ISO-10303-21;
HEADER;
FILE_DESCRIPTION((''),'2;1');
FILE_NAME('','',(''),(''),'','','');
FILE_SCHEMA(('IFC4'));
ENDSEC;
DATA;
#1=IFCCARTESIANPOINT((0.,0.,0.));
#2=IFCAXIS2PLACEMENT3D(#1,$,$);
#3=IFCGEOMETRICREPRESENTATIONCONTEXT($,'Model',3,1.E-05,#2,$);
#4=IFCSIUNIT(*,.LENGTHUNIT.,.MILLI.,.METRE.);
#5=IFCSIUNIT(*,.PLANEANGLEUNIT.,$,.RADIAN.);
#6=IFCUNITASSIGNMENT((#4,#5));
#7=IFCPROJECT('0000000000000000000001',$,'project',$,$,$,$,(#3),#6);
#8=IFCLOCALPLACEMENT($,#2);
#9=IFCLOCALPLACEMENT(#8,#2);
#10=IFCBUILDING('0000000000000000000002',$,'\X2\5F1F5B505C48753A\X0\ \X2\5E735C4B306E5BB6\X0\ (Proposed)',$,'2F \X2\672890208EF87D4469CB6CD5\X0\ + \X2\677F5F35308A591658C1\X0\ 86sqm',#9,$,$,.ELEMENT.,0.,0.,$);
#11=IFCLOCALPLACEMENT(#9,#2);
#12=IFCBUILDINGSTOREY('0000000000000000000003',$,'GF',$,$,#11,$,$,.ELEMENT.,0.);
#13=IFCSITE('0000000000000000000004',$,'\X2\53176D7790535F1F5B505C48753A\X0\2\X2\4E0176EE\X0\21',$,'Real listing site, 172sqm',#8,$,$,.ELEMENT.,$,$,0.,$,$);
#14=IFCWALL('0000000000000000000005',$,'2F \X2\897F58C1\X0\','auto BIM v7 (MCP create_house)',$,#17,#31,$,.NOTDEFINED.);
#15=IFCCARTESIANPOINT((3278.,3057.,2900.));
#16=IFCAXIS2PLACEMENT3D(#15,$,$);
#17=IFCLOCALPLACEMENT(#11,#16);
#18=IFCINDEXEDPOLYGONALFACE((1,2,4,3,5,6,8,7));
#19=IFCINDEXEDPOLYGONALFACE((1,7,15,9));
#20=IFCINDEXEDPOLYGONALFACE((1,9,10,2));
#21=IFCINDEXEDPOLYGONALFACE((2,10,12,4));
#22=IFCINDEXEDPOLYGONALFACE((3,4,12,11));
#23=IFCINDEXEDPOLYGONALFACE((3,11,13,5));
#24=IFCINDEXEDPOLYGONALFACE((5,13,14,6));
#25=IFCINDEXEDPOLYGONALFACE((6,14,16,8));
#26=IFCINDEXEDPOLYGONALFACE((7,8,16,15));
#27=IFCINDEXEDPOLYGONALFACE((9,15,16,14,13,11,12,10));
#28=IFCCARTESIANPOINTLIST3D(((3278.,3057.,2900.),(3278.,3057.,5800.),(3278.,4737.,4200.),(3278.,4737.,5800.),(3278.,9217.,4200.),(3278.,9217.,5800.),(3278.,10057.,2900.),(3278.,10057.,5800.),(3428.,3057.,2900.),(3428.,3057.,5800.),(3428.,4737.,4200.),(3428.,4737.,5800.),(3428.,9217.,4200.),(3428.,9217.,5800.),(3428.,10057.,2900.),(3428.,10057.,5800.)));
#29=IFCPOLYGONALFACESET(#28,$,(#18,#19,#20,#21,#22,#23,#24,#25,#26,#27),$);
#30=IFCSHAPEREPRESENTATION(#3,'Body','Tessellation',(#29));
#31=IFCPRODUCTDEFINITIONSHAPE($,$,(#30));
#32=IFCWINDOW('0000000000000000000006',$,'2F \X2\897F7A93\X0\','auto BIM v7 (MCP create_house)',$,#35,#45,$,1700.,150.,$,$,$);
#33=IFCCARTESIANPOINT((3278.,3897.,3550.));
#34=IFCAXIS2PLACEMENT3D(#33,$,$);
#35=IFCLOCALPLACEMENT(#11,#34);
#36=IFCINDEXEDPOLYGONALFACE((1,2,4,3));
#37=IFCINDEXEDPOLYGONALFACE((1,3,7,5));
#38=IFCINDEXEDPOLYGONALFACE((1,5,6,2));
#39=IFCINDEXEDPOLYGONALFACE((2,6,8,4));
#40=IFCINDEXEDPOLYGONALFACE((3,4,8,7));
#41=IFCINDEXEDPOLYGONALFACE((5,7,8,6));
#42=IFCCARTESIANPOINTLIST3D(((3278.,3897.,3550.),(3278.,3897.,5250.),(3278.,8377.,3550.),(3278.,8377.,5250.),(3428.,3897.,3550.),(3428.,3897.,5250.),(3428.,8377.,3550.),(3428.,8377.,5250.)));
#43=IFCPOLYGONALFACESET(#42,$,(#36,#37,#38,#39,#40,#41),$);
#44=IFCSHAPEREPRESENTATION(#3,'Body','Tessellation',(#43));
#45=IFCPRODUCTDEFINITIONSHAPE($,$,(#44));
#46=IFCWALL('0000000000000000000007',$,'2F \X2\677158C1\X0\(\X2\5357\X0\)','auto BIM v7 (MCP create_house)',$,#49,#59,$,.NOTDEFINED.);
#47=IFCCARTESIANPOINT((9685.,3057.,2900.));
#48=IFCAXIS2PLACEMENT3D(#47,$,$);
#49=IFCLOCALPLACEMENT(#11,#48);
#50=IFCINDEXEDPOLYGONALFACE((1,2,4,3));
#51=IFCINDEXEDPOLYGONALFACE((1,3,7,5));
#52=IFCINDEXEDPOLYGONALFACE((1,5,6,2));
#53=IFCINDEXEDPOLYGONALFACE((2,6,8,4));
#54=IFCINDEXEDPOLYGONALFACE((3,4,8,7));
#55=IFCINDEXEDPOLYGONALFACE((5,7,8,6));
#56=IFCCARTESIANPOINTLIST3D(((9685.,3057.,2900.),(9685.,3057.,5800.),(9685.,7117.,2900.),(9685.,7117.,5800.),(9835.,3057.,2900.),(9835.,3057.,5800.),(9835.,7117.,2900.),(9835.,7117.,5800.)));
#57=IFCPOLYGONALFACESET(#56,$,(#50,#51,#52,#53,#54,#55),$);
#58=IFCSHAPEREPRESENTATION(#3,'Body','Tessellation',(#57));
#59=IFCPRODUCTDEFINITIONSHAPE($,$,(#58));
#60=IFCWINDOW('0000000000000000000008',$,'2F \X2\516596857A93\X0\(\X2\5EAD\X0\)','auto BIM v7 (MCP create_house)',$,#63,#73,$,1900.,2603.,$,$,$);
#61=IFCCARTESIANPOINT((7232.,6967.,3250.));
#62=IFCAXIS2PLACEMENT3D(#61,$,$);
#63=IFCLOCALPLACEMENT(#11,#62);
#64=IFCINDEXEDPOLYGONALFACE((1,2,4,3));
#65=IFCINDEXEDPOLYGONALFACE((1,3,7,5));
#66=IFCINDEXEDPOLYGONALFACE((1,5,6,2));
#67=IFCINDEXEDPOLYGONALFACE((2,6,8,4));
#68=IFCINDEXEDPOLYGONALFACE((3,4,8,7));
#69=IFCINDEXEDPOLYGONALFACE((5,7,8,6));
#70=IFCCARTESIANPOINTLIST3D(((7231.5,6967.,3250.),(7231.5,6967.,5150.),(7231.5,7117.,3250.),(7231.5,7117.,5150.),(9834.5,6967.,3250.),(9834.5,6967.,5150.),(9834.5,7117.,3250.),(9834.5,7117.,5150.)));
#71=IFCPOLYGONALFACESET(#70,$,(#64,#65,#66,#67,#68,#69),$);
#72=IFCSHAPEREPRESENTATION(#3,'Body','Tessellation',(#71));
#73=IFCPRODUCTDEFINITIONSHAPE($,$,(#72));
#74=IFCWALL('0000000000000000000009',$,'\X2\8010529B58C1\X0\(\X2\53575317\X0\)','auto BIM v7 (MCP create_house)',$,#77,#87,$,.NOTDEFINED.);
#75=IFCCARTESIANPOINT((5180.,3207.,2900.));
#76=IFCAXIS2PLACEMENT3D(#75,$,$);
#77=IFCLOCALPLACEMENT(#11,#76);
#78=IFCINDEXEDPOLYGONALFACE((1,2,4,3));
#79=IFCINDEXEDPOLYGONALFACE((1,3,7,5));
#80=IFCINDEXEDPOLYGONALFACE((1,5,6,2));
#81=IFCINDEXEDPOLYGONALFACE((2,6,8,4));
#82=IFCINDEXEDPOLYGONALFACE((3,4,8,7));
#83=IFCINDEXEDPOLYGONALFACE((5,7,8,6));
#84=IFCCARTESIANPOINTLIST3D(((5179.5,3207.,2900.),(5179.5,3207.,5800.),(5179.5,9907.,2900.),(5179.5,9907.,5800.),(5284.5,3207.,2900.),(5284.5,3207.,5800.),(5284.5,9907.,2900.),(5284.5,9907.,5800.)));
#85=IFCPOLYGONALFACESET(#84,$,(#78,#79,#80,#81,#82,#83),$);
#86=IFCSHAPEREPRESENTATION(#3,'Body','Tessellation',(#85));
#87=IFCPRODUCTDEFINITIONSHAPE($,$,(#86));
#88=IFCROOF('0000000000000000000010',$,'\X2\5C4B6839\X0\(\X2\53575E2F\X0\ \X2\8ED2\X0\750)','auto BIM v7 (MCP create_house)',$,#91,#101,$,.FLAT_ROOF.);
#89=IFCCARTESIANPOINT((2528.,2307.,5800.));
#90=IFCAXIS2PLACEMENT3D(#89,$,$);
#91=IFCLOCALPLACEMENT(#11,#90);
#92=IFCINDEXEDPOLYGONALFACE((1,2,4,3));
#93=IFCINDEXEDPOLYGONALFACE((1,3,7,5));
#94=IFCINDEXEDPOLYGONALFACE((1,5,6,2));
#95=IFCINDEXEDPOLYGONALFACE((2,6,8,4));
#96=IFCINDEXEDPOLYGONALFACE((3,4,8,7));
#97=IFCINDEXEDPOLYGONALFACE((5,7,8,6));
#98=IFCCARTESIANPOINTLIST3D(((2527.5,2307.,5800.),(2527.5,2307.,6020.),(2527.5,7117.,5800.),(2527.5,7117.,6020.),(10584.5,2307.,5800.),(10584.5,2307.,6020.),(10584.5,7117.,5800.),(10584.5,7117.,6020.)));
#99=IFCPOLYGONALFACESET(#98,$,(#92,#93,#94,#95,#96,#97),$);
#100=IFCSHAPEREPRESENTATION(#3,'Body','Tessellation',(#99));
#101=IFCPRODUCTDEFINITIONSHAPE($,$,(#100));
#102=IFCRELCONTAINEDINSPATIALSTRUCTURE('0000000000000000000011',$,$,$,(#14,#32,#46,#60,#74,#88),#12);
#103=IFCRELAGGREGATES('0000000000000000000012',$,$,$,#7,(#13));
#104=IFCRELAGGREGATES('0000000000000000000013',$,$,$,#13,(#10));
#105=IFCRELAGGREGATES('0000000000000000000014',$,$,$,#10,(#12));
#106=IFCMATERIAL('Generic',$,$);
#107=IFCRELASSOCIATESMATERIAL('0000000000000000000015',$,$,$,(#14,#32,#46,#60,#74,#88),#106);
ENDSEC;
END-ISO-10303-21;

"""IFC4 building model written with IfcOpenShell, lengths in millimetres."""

from ifc_helpers import new_model, si_unit, frame, frame_2d, origin, place, context, project, spatial, rectangle, extrude, material, element, fill, save


model = new_model("IFC4")

# Units and contexts
model_context = context("Model", 3, precision=1e-05, world=origin())
ifc_project = project(units=[si_unit("LENGTHUNIT", "METRE", prefix="MILLI"), si_unit("PLANEANGLEUNIT", "RADIAN")], contexts=[model_context])

# Site, building, storey
site_placement = place(None, origin())
site = spatial("IfcSite", under=ifc_project, at=site_placement, Name="北海道弟子屈町2丁目21", ObjectType="Real listing site, 172sqm", CompositionType="ELEMENT", RefElevation=0.0)
building_placement = place(site_placement, origin())
building = spatial("IfcBuilding", under=site, at=building_placement, Name="弟子屈町 平屋の家 (Proposed)", ObjectType="2F 木造軸組構法 + 板張り外壁 86sqm", CompositionType="ELEMENT", ElevationOfRefHeight=0.0, ElevationOfTerrain=0.0)
storey_placement = place(building_placement, origin())
storey = spatial("IfcBuildingStorey", under=building, at=storey_placement, Name="GF", CompositionType="ELEMENT", Elevation=0.0)

# Shared definitions
ifc_material = material(Name="Generic")

# Walls, openings, windows
wall_1_placement = place(storey_placement, frame((3278.0, 3057.0, 2900.0)))
wall_1 = element("IfcWall", 1, at=wall_1_placement, inside=storey, material=ifc_material, Name="2F 西壁", Description="auto BIM v7 (MCP create_house)", PredefinedType="NOTDEFINED", context=model_context, shape_type="SweptSolid", body=[
    extrude(rectangle(XDim=150.0, YDim=7000.0, at=frame_2d((75.0, 3500.0))), frame((3278.0, 3057.0, 2900.0)), (0.0, 0.0, 1.0), 2900.0),
])
opening_1_placement = place(storey_placement, frame((3278.0, 3897.0, 3550.0)))
opening_1 = element("IfcOpeningElement", 2, at=opening_1_placement, cuts=wall_1, PredefinedType="NOTDEFINED", context=model_context, shape_type="SweptSolid", body=[
    extrude(rectangle(XDim=150.0, YDim=4480.0, at=frame_2d((75.0, 2240.0))), frame((3278.0, 3897.0, 3550.0)), (0.0, 0.0, 1.0), 1700.0),
])
window_1_placement = place(storey_placement, frame((3278.0, 3897.0, 3550.0)))
window_1 = element("IfcWindow", 3, at=window_1_placement, inside=storey, material=ifc_material, Name="2F 西窓", Description="auto BIM v7 (MCP create_house)", OverallHeight=1700.0, OverallWidth=150.0, context=model_context, shape_type="SweptSolid", body=[
    extrude(rectangle(XDim=150.0, YDim=4480.0, at=frame_2d((75.0, 2240.0))), frame((3278.0, 3897.0, 3550.0)), (0.0, 0.0, 1.0), 1700.0),
])
fill(opening_1, window_1)
wall_2_placement = place(storey_placement, frame((9685.0, 3057.0, 2900.0)))
wall_2 = element("IfcWall", 4, at=wall_2_placement, inside=storey, material=ifc_material, Name="2F 東壁(南)", Description="auto BIM v7 (MCP create_house)", PredefinedType="NOTDEFINED", context=model_context, shape_type="SweptSolid", body=[
    extrude(rectangle(XDim=150.0, YDim=4060.0, at=frame_2d((75.0, 2030.0))), frame((9685.0, 3057.0, 2900.0)), (0.0, 0.0, 1.0), 2900.0),
])
opening_2_placement = place(storey_placement, frame((7232.0, 6967.0, 3250.0)))
opening_2 = element("IfcOpeningElement", 5, at=opening_2_placement, cuts=wall_2, PredefinedType="NOTDEFINED", context=model_context, shape_type="SweptSolid", body=[
    extrude(rectangle(XDim=2603.0, YDim=150.0, at=frame_2d((1301.0, 75.0))), frame((7232.0, 6967.0, 3250.0)), (0.0, 0.0, 1.0), 1900.0),
])
window_2_placement = place(storey_placement, frame((7232.0, 6967.0, 3250.0)))
window_2 = element("IfcWindow", 6, at=window_2_placement, inside=storey, material=ifc_material, Name="2F 入隅窓(庭)", Description="auto BIM v7 (MCP create_house)", OverallHeight=1900.0, OverallWidth=2603.0, context=model_context, shape_type="SweptSolid", body=[
    extrude(rectangle(XDim=2603.0, YDim=150.0, at=frame_2d((1301.0, 75.0))), frame((7232.0, 6967.0, 3250.0)), (0.0, 0.0, 1.0), 1900.0),
])
fill(opening_2, window_2)

# Wall
wall_3_placement = place(storey_placement, frame((5180.0, 3207.0, 2900.0)))
element("IfcWall", 7, at=wall_3_placement, inside=storey, material=ifc_material, Name="耐力壁(南北)", Description="auto BIM v7 (MCP create_house)", PredefinedType="NOTDEFINED", context=model_context, shape_type="SweptSolid", body=[
    extrude(rectangle(XDim=105.0, YDim=6700.0, at=frame_2d((52.0, 3350.0))), frame((5180.0, 3207.0, 2900.0)), (0.0, 0.0, 1.0), 2900.0),
])

# Roof
for number, where, name in (
    (8, (2528.0, 2307.0, 5800.0), "屋根(南帯 軒750)"),
):
    element("IfcRoof", number, at=place(storey_placement, frame(where)), inside=storey, material=ifc_material, Name=name, Description="auto BIM v7 (MCP create_house)", PredefinedType="FLAT_ROOF", context=model_context, shape_type="SweptSolid", body=[
        extrude(rectangle(XDim=8057.0, YDim=4810.0, at=frame_2d((4028.0, 2405.0))), frame((2528.0, 2307.0, 5800.0)), (0.0, 0.0, 1.0), 220.0),
    ])

save(model, "model.ifc")
